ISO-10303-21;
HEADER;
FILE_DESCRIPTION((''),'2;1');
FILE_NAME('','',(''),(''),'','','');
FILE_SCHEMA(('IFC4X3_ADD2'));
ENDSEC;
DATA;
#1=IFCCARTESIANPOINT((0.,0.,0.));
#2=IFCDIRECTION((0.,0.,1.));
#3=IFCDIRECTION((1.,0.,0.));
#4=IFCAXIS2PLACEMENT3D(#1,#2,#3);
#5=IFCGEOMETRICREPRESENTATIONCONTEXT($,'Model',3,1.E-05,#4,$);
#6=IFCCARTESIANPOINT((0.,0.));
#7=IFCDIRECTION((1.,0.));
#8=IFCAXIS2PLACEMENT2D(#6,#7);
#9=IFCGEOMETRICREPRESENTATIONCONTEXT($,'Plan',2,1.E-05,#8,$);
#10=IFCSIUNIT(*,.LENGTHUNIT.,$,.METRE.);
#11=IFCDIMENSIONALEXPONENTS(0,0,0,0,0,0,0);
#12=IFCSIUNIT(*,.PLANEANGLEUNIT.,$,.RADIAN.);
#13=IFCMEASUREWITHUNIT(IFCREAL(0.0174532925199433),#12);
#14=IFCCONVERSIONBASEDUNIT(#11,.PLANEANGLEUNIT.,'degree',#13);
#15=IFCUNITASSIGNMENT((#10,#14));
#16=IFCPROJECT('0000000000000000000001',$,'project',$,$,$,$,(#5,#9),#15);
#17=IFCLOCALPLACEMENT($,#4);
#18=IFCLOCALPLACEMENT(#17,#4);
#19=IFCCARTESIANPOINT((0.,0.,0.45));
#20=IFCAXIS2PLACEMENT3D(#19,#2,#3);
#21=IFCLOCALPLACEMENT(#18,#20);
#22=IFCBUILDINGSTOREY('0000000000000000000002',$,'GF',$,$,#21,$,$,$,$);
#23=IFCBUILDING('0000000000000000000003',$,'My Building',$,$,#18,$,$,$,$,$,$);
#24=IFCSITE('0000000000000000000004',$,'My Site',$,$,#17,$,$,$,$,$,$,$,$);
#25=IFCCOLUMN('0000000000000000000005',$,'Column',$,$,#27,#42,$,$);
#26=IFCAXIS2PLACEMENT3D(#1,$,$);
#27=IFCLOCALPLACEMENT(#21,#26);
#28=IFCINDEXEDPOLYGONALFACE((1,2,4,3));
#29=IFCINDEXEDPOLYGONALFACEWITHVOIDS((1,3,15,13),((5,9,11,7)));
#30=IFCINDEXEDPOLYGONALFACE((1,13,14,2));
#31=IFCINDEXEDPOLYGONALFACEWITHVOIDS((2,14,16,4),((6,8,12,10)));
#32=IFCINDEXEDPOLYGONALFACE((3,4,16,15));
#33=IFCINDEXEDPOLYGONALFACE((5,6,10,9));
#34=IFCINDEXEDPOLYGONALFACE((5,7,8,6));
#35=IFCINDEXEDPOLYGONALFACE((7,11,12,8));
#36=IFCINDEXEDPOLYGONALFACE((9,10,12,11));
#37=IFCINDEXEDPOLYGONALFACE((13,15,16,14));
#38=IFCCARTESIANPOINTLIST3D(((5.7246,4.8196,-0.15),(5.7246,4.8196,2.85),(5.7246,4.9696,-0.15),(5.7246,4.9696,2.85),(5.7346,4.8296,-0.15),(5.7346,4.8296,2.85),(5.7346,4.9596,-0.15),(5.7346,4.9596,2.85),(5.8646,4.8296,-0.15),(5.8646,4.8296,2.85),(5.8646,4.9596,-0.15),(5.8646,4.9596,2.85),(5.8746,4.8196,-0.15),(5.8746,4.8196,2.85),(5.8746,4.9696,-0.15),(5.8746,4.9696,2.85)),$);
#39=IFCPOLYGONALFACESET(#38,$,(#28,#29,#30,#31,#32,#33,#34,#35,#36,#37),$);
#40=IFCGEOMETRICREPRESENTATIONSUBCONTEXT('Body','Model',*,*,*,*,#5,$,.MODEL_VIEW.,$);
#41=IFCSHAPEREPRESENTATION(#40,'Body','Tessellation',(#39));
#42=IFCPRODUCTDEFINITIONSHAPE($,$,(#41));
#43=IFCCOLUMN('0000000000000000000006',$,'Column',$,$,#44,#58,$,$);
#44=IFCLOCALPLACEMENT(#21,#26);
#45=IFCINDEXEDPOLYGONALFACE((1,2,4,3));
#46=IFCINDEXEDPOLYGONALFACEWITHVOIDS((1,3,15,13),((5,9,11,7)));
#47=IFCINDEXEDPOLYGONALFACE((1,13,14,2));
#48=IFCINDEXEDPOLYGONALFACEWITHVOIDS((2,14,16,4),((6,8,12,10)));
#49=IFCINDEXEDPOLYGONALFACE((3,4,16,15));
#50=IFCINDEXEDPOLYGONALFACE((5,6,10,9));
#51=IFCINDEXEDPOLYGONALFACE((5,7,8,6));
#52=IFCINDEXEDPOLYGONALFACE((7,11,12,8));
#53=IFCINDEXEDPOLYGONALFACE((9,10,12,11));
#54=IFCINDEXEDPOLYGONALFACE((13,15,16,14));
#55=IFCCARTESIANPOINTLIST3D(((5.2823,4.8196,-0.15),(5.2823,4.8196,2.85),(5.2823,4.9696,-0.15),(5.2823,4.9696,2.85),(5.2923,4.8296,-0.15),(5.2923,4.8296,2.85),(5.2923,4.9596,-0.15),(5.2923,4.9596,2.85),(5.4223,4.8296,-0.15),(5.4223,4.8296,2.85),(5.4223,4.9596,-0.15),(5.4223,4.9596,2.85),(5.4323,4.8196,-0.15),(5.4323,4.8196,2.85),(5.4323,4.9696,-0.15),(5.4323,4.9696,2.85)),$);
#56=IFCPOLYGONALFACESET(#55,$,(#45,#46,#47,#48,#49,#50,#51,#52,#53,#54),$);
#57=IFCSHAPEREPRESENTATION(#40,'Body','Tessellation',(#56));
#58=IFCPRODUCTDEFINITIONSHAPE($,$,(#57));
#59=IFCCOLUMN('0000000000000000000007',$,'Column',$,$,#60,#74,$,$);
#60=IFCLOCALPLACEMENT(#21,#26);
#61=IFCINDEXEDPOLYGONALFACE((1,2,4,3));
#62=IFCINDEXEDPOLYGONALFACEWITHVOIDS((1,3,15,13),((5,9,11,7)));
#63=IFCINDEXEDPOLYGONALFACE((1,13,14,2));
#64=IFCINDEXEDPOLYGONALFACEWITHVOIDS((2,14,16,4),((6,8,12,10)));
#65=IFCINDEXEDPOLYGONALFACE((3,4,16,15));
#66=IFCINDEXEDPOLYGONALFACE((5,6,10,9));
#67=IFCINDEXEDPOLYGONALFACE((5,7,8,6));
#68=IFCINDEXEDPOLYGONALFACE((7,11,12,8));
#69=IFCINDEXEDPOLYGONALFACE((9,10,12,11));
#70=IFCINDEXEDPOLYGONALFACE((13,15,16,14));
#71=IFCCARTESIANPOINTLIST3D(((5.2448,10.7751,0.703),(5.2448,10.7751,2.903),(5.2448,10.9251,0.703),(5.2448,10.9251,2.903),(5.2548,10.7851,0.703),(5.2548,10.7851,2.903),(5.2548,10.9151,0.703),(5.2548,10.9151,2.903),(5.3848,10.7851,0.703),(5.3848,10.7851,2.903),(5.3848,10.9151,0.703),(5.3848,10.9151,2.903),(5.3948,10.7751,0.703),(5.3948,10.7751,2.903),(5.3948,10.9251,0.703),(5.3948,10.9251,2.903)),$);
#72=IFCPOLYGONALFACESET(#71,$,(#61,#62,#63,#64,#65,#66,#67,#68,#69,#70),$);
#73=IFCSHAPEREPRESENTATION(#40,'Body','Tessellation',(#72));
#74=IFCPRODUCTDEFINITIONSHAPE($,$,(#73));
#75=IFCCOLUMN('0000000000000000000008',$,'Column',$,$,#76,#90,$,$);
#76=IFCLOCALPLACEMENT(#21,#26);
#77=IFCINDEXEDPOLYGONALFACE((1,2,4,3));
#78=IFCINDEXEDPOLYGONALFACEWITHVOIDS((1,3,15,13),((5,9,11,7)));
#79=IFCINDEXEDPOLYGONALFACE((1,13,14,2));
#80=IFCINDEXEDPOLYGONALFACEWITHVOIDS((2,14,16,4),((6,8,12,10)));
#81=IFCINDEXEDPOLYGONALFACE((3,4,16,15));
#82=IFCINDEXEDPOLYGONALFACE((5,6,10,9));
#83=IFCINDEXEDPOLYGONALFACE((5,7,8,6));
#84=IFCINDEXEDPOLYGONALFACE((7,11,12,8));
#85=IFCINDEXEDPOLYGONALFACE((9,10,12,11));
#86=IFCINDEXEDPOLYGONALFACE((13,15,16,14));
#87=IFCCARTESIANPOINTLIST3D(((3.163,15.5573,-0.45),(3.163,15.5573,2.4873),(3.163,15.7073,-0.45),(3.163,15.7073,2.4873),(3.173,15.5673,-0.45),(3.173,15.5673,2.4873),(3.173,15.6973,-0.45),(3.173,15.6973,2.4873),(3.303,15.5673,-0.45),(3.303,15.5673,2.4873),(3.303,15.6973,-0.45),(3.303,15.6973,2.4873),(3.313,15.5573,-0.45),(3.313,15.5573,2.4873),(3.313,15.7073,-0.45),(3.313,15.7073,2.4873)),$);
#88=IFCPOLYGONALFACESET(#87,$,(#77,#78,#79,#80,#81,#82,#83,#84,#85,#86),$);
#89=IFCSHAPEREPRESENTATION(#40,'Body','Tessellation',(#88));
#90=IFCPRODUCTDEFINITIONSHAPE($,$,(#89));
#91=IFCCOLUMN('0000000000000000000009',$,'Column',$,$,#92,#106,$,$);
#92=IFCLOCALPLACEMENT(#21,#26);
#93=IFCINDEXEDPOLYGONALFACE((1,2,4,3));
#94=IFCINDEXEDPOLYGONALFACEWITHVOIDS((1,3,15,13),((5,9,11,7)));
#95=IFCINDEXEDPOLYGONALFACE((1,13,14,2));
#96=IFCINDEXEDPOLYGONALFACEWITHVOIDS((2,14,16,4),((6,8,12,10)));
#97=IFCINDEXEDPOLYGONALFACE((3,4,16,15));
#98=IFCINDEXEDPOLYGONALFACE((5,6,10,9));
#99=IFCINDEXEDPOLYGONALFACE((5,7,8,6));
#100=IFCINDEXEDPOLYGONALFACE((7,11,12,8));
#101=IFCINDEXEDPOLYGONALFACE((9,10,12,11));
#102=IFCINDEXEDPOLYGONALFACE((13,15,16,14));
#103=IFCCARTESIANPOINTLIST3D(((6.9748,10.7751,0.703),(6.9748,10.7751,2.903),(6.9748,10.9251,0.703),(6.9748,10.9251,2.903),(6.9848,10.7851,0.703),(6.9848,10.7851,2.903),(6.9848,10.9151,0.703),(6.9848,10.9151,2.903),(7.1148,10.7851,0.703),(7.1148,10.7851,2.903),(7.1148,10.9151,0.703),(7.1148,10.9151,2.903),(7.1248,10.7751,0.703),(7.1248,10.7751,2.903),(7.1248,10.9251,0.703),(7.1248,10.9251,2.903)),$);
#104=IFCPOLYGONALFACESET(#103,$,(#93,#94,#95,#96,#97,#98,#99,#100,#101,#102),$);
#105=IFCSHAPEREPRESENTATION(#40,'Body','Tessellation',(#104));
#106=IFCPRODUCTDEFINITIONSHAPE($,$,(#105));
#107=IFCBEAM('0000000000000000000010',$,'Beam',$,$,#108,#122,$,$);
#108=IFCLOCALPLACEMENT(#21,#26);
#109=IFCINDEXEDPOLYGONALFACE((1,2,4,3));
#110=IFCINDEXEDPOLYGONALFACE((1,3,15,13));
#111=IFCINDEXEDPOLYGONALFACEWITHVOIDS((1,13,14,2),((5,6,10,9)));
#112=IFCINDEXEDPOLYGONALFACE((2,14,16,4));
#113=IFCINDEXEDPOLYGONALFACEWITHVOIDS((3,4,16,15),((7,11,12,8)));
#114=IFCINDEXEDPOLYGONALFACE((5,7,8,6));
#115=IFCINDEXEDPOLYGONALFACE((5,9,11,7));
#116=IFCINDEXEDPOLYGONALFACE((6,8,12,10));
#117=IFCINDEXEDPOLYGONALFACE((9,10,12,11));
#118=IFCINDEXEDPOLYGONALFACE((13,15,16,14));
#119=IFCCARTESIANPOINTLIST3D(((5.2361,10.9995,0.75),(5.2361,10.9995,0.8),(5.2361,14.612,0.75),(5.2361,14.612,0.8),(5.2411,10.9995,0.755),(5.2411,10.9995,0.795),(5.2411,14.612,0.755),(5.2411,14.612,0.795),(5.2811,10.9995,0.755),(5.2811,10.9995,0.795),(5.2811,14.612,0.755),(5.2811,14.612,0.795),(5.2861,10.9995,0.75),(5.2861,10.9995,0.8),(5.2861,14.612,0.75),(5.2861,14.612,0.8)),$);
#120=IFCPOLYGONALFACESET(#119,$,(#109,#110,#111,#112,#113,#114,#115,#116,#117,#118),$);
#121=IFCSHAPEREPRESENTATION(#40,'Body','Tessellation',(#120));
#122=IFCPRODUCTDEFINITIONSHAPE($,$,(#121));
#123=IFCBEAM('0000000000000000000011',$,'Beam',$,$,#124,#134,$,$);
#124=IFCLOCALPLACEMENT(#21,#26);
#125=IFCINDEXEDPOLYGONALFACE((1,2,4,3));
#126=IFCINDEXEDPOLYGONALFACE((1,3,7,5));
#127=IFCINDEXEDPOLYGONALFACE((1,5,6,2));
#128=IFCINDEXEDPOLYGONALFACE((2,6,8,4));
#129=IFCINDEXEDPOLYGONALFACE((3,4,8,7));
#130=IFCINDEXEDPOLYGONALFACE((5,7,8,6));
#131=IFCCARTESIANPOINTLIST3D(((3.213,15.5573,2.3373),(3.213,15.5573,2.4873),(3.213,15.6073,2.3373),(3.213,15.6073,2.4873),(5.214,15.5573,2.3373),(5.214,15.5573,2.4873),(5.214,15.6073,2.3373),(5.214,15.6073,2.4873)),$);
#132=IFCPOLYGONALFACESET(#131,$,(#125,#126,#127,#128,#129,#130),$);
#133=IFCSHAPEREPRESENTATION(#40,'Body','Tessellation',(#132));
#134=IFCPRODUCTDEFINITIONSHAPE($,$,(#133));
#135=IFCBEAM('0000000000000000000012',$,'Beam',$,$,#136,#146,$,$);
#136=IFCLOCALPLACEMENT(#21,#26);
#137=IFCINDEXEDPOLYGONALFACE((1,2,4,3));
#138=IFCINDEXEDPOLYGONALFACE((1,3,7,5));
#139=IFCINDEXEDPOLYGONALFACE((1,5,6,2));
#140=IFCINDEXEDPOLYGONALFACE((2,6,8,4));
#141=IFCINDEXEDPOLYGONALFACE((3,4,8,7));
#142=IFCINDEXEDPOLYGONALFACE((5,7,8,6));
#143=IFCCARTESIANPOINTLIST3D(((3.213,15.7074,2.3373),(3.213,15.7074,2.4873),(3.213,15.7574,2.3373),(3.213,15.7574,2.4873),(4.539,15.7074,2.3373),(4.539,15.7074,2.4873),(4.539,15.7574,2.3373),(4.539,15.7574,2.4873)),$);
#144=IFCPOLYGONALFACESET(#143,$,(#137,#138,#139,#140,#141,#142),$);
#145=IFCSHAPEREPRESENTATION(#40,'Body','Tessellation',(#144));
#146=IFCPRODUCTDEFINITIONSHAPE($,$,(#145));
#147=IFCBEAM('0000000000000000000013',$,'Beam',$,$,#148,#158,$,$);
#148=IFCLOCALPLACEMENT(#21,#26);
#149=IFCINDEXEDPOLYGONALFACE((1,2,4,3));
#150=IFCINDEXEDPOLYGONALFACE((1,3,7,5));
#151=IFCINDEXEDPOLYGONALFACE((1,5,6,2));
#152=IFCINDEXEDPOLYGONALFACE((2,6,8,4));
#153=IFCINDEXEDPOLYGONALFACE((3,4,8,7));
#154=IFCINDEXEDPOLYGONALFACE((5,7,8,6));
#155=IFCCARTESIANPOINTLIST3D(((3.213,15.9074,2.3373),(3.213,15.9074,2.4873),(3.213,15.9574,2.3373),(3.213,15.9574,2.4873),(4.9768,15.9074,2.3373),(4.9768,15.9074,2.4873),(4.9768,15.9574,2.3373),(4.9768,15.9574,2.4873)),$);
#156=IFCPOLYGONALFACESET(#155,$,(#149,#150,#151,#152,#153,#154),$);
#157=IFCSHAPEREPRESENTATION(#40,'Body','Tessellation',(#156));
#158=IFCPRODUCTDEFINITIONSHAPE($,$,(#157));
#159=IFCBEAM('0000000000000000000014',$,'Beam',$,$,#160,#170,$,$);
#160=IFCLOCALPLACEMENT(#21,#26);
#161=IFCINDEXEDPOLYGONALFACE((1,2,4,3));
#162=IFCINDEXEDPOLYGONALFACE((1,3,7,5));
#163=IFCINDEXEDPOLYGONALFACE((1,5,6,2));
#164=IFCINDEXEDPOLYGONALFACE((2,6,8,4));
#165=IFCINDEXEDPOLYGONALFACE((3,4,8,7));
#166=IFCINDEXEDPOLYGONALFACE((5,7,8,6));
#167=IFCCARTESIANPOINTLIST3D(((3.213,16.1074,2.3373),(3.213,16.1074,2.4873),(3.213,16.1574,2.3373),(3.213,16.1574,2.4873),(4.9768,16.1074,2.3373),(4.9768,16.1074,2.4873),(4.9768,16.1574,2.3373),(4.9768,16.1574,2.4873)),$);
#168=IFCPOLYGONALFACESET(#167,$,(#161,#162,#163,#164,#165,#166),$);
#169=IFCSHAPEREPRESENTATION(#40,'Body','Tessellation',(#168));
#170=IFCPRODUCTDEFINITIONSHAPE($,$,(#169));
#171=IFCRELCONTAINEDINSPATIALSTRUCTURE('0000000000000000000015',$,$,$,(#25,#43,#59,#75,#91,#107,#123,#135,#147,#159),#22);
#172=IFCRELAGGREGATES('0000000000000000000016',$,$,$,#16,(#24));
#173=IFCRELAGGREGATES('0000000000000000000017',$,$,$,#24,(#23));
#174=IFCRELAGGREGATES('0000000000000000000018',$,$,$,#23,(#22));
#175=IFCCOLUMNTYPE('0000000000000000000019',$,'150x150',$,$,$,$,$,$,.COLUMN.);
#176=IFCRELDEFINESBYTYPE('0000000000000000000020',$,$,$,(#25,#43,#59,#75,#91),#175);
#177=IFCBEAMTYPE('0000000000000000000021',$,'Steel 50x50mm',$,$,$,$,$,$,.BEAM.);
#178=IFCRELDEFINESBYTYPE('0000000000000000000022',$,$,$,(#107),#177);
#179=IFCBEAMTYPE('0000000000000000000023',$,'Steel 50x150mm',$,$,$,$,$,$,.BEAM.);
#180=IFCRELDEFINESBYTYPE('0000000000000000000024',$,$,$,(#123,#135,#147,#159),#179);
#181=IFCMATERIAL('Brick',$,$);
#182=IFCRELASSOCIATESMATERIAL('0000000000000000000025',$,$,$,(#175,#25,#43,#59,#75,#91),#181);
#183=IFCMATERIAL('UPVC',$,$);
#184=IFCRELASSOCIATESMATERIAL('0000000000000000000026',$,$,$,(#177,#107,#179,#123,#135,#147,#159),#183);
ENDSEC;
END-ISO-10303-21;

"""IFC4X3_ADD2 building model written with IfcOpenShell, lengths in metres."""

from ifc_helpers import new_model, entity, si_unit, converted_unit, frame, origin_with_axes, origin_2d_with_axis, place, context, subcontext, project, spatial, rectangle, hollow_rectangle, extrude, shape, material, material_profile, profile_set, profile_usage, type_object, element, save


model = new_model("IFC4X3_ADD2")

# Units and contexts
model_context = context("Model", 3, precision=1e-05, world=origin_with_axes())
plan_context = context("Plan", 2, precision=1e-05, world=origin_2d_with_axis())
body_context_1 = subcontext(model_context, "Body", "Model", "MODEL_VIEW")
body_context_2 = subcontext(plan_context, "Body", "Plan", "PLAN_VIEW")
ifc_project = project(units=[si_unit("LENGTHUNIT", "METRE"), converted_unit("PLANEANGLEUNIT", "degree", entity("IfcReal", 0.0174532925199433), si_unit("PLANEANGLEUNIT", "RADIAN"), dimensions=[0, 0, 0, 0, 0, 0, 0])], contexts=[model_context, plan_context])

# Site, building, storey
site_placement = place(None, origin_with_axes())
site = spatial("IfcSite", under=ifc_project, at=site_placement, Name="My Site")
building_placement = place(site_placement, origin_with_axes())
building = spatial("IfcBuilding", under=site, at=building_placement, Name="My Building")
storey_placement = place(building_placement, frame((0.0, 0.0, 0.45), z_axis=(0.0, 0.0, 1.0), x_axis=(1.0, 0.0, 0.0)))
storey = spatial("IfcBuildingStorey", under=building, at=storey_placement, Name="GF")

# Columns
ifc_material_1 = material(Name="Brick")
ifc_material_profile_1 = material_profile(ifc_material_1, hollow_rectangle(XDim=0.15, YDim=0.15, WallThickness=0.01))
ifc_profile_set_1 = profile_set([ifc_material_profile_1])
ifc_profile_usage_1 = profile_usage(ifc_profile_set_1, cardinal=5)
column_type = type_object("IfcColumnType", Name="150x150", PredefinedType="COLUMN", material=ifc_profile_set_1)
column_1_placement = place(storey_placement, frame((5.7996, 4.8946, -0.15), z_axis=(0.0, 0.0, 1.0), x_axis=(1.0, 0.0, 0.0)))
element("IfcColumn", 1, at=column_1_placement, inside=storey, type_object=column_type, material=ifc_profile_usage_1, Name="Column", shapes=[
    shape(body_context_1, "Body", "SweptSolid", [extrude(hollow_rectangle(XDim=0.15, YDim=0.15, WallThickness=0.01), origin_with_axes(), (0.0, 0.0, 1.0), 3.0)]),
    shape(body_context_2, "Body", "Annotation2D", [entity("IfcGeometricCurveSet", [entity("IfcIndexedPolyCurve", entity("IfcCartesianPointList2D", [[0.075, -0.075], [0.075, 0.075], [-0.075, 0.075], [-0.075, -0.075]]), [entity("IfcLineIndex", [1, 2, 3, 4, 1])]), entity("IfcIndexedPolyCurve", entity("IfcCartesianPointList2D", [[-0.065, 0.065], [-0.065, -0.065], [0.065, -0.065], [0.065, 0.065]]), [entity("IfcLineIndex", [1, 2, 3, 4, 1])])])]),
])
ifc_profile_usage_2 = profile_usage(ifc_profile_set_1, cardinal=5)
column_2_placement = place(storey_placement, frame((5.3573, 4.8946, -0.15), z_axis=(0.0, 0.0, 1.0), x_axis=(1.0, 0.0, 0.0)))
element("IfcColumn", 2, at=column_2_placement, inside=storey, type_object=column_type, material=ifc_profile_usage_2, Name="Column", shapes=[
    shape(body_context_1, "Body", "SweptSolid", [extrude(hollow_rectangle(XDim=0.15, YDim=0.15, WallThickness=0.01), origin_with_axes(), (0.0, 0.0, 1.0), 3.0)]),
    shape(body_context_2, "Body", "Annotation2D", [entity("IfcGeometricCurveSet", [entity("IfcIndexedPolyCurve", entity("IfcCartesianPointList2D", [[0.065, 0.065], [-0.065, 0.065], [-0.065, -0.065], [0.065, -0.065]]), [entity("IfcLineIndex", [1, 2, 3, 4, 1])]), entity("IfcIndexedPolyCurve", entity("IfcCartesianPointList2D", [[0.075, -0.075], [0.075, 0.075], [-0.075, 0.075], [-0.075, -0.075]]), [entity("IfcLineIndex", [1, 2, 3, 4, 1])])])]),
])
ifc_profile_usage_3 = profile_usage(ifc_profile_set_1, cardinal=5)
column_3_placement = place(storey_placement, frame((5.3198, 10.8501, 0.703), z_axis=(0.0, 0.0, 1.0), x_axis=(1.0, 0.0, 0.0)))
element("IfcColumn", 3, at=column_3_placement, inside=storey, type_object=column_type, material=ifc_profile_usage_3, Name="Column", shapes=[
    shape(body_context_1, "Body", "SweptSolid", [extrude(hollow_rectangle(XDim=0.15, YDim=0.15, WallThickness=0.01), origin_with_axes(), (0.0, 0.0, 1.0), 2.2)]),
    shape(body_context_2, "Body", "Annotation2D", [entity("IfcGeometricCurveSet", [entity("IfcIndexedPolyCurve", entity("IfcCartesianPointList2D", [[0.065, -0.065], [0.065, 0.065], [-0.065, 0.065], [-0.065, -0.065]]), [entity("IfcLineIndex", [1, 2, 3, 4, 1])]), entity("IfcIndexedPolyCurve", entity("IfcCartesianPointList2D", [[-0.075, -0.075], [0.075, -0.075], [0.075, 0.075], [-0.075, 0.075]]), [entity("IfcLineIndex", [1, 2, 3, 4, 1])])])]),
])
ifc_profile_usage_4 = profile_usage(ifc_profile_set_1, cardinal=5)
column_4_placement = place(storey_placement, frame((3.238, 15.6323, -0.45), z_axis=(0.0, 0.0, 1.0), x_axis=(1.0, 0.0, 0.0)))
element("IfcColumn", 4, at=column_4_placement, inside=storey, type_object=column_type, material=ifc_profile_usage_4, Name="Column", shapes=[
    shape(body_context_1, "Body", "SweptSolid", [extrude(hollow_rectangle(XDim=0.15, YDim=0.15, WallThickness=0.01), origin_with_axes(), (0.0, 0.0, 1.0), 2.9373)]),
    shape(body_context_2, "Body", "Annotation2D", [entity("IfcGeometricCurveSet", [entity("IfcIndexedPolyCurve", entity("IfcCartesianPointList2D", [[0.075, -0.075], [-0.075, -0.075], [-0.075, 0.075], [0.075, 0.075]]), [entity("IfcLineIndex", [1, 2, 3, 4, 1])]), entity("IfcIndexedPolyCurve", entity("IfcCartesianPointList2D", [[-0.065, -0.065], [0.065, -0.065], [0.065, 0.065], [-0.065, 0.065]]), [entity("IfcLineIndex", [1, 2, 3, 4, 1])])])]),
])
ifc_profile_usage_5 = profile_usage(ifc_profile_set_1, cardinal=5)
column_5_placement = place(storey_placement, frame((7.0498, 10.8501, 0.703), z_axis=(0.0, 0.0, 1.0), x_axis=(1.0, 0.0, 0.0)))
element("IfcColumn", 5, at=column_5_placement, inside=storey, type_object=column_type, material=ifc_profile_usage_5, Name="Column", shapes=[
    shape(body_context_1, "Body", "SweptSolid", [extrude(hollow_rectangle(XDim=0.15, YDim=0.15, WallThickness=0.01), origin_with_axes(), (0.0, 0.0, 1.0), 2.2)]),
    shape(body_context_2, "Body", "Annotation2D", [entity("IfcGeometricCurveSet", [entity("IfcIndexedPolyCurve", entity("IfcCartesianPointList2D", [[0.065, -0.065], [0.065, 0.065], [-0.065, 0.065], [-0.065, -0.065]]), [entity("IfcLineIndex", [1, 2, 3, 4, 1])]), entity("IfcIndexedPolyCurve", entity("IfcCartesianPointList2D", [[-0.075, -0.075], [0.075, -0.075], [0.075, 0.075], [-0.075, 0.075]]), [entity("IfcLineIndex", [1, 2, 3, 4, 1])])])]),
])

# Beams
ifc_material_2 = material(Name="UPVC")
ifc_material_profile_2 = material_profile(ifc_material_2, hollow_rectangle(XDim=0.05, YDim=0.05, WallThickness=0.005))
ifc_profile_set_2 = profile_set([ifc_material_profile_2])
ifc_profile_usage_6 = profile_usage(ifc_profile_set_2)
beam_type_1 = type_object("IfcBeamType", Name="Steel 50x50mm", PredefinedType="BEAM", material=ifc_profile_set_2)
beam_1_placement = place(storey_placement, frame((5.2611, 14.612, 0.775), z_axis=(0.0, -1.0, 0.0), x_axis=(1.0, 0.0, 0.0)))
element("IfcBeam", 6, at=beam_1_placement, inside=storey, type_object=beam_type_1, material=ifc_profile_usage_6, Name="Beam", context=body_context_1, shape_type="SweptSolid", body=[
    extrude(hollow_rectangle(XDim=0.05, YDim=0.05, WallThickness=0.005), origin_with_axes(), (0.0, 0.0, 1.0), 3.6125),
])
ifc_material_profile_3 = material_profile(ifc_material_2, rectangle(XDim=0.05, YDim=0.15))
ifc_profile_set_3 = profile_set([ifc_material_profile_3])
ifc_profile_usage_7 = profile_usage(ifc_profile_set_3)
beam_type_2 = type_object("IfcBeamType", Name="Steel 50x150mm", PredefinedType="BEAM", material=ifc_profile_set_3)
beam_2_placement = place(storey_placement, frame((3.213, 15.5823, 2.4123), z_axis=(1.0, 0.0, 0.0), x_axis=(0.0, 1.0, 0.0)))
element("IfcBeam", 7, at=beam_2_placement, inside=storey, type_object=beam_type_2, material=ifc_profile_usage_7, Name="Beam", context=body_context_1, shape_type="SweptSolid", body=[
    extrude(rectangle(XDim=0.05, YDim=0.15), origin_with_axes(), (0.0, 0.0, 1.0), 2.001),
])
ifc_profile_usage_8 = profile_usage(ifc_profile_set_3)
beam_3_placement = place(storey_placement, frame((3.213, 15.7324, 2.4123), z_axis=(1.0, 0.0, 0.0), x_axis=(0.0, 1.0, 0.0)))
element("IfcBeam", 8, at=beam_3_placement, inside=storey, type_object=beam_type_2, material=ifc_profile_usage_8, Name="Beam", context=body_context_1, shape_type="SweptSolid", body=[
    extrude(rectangle(XDim=0.05, YDim=0.15), origin_with_axes(), (0.0, 0.0, 1.0), 1.326),
])
ifc_profile_usage_9 = profile_usage(ifc_profile_set_3)
beam_4_placement = place(storey_placement, frame((3.213, 15.9324, 2.4123), z_axis=(1.0, 0.0, 0.0), x_axis=(0.0, 1.0, 0.0)))
element("IfcBeam", 9, at=beam_4_placement, inside=storey, type_object=beam_type_2, material=ifc_profile_usage_9, Name="Beam", context=body_context_1, shape_type="SweptSolid", body=[
    extrude(rectangle(XDim=0.05, YDim=0.15), origin_with_axes(), (0.0, 0.0, 1.0), 1.7638),
])
ifc_profile_usage_10 = profile_usage(ifc_profile_set_3)
beam_5_placement = place(storey_placement, frame((3.213, 16.1324, 2.4123), z_axis=(1.0, 0.0, 0.0), x_axis=(0.0, 1.0, 0.0)))
element("IfcBeam", 10, at=beam_5_placement, inside=storey, type_object=beam_type_2, material=ifc_profile_usage_10, Name="Beam", context=body_context_1, shape_type="SweptSolid", body=[
    extrude(rectangle(XDim=0.05, YDim=0.15), origin_with_axes(), (0.0, 0.0, 1.0), 1.7638),
])

save(model, "model.ifc")
